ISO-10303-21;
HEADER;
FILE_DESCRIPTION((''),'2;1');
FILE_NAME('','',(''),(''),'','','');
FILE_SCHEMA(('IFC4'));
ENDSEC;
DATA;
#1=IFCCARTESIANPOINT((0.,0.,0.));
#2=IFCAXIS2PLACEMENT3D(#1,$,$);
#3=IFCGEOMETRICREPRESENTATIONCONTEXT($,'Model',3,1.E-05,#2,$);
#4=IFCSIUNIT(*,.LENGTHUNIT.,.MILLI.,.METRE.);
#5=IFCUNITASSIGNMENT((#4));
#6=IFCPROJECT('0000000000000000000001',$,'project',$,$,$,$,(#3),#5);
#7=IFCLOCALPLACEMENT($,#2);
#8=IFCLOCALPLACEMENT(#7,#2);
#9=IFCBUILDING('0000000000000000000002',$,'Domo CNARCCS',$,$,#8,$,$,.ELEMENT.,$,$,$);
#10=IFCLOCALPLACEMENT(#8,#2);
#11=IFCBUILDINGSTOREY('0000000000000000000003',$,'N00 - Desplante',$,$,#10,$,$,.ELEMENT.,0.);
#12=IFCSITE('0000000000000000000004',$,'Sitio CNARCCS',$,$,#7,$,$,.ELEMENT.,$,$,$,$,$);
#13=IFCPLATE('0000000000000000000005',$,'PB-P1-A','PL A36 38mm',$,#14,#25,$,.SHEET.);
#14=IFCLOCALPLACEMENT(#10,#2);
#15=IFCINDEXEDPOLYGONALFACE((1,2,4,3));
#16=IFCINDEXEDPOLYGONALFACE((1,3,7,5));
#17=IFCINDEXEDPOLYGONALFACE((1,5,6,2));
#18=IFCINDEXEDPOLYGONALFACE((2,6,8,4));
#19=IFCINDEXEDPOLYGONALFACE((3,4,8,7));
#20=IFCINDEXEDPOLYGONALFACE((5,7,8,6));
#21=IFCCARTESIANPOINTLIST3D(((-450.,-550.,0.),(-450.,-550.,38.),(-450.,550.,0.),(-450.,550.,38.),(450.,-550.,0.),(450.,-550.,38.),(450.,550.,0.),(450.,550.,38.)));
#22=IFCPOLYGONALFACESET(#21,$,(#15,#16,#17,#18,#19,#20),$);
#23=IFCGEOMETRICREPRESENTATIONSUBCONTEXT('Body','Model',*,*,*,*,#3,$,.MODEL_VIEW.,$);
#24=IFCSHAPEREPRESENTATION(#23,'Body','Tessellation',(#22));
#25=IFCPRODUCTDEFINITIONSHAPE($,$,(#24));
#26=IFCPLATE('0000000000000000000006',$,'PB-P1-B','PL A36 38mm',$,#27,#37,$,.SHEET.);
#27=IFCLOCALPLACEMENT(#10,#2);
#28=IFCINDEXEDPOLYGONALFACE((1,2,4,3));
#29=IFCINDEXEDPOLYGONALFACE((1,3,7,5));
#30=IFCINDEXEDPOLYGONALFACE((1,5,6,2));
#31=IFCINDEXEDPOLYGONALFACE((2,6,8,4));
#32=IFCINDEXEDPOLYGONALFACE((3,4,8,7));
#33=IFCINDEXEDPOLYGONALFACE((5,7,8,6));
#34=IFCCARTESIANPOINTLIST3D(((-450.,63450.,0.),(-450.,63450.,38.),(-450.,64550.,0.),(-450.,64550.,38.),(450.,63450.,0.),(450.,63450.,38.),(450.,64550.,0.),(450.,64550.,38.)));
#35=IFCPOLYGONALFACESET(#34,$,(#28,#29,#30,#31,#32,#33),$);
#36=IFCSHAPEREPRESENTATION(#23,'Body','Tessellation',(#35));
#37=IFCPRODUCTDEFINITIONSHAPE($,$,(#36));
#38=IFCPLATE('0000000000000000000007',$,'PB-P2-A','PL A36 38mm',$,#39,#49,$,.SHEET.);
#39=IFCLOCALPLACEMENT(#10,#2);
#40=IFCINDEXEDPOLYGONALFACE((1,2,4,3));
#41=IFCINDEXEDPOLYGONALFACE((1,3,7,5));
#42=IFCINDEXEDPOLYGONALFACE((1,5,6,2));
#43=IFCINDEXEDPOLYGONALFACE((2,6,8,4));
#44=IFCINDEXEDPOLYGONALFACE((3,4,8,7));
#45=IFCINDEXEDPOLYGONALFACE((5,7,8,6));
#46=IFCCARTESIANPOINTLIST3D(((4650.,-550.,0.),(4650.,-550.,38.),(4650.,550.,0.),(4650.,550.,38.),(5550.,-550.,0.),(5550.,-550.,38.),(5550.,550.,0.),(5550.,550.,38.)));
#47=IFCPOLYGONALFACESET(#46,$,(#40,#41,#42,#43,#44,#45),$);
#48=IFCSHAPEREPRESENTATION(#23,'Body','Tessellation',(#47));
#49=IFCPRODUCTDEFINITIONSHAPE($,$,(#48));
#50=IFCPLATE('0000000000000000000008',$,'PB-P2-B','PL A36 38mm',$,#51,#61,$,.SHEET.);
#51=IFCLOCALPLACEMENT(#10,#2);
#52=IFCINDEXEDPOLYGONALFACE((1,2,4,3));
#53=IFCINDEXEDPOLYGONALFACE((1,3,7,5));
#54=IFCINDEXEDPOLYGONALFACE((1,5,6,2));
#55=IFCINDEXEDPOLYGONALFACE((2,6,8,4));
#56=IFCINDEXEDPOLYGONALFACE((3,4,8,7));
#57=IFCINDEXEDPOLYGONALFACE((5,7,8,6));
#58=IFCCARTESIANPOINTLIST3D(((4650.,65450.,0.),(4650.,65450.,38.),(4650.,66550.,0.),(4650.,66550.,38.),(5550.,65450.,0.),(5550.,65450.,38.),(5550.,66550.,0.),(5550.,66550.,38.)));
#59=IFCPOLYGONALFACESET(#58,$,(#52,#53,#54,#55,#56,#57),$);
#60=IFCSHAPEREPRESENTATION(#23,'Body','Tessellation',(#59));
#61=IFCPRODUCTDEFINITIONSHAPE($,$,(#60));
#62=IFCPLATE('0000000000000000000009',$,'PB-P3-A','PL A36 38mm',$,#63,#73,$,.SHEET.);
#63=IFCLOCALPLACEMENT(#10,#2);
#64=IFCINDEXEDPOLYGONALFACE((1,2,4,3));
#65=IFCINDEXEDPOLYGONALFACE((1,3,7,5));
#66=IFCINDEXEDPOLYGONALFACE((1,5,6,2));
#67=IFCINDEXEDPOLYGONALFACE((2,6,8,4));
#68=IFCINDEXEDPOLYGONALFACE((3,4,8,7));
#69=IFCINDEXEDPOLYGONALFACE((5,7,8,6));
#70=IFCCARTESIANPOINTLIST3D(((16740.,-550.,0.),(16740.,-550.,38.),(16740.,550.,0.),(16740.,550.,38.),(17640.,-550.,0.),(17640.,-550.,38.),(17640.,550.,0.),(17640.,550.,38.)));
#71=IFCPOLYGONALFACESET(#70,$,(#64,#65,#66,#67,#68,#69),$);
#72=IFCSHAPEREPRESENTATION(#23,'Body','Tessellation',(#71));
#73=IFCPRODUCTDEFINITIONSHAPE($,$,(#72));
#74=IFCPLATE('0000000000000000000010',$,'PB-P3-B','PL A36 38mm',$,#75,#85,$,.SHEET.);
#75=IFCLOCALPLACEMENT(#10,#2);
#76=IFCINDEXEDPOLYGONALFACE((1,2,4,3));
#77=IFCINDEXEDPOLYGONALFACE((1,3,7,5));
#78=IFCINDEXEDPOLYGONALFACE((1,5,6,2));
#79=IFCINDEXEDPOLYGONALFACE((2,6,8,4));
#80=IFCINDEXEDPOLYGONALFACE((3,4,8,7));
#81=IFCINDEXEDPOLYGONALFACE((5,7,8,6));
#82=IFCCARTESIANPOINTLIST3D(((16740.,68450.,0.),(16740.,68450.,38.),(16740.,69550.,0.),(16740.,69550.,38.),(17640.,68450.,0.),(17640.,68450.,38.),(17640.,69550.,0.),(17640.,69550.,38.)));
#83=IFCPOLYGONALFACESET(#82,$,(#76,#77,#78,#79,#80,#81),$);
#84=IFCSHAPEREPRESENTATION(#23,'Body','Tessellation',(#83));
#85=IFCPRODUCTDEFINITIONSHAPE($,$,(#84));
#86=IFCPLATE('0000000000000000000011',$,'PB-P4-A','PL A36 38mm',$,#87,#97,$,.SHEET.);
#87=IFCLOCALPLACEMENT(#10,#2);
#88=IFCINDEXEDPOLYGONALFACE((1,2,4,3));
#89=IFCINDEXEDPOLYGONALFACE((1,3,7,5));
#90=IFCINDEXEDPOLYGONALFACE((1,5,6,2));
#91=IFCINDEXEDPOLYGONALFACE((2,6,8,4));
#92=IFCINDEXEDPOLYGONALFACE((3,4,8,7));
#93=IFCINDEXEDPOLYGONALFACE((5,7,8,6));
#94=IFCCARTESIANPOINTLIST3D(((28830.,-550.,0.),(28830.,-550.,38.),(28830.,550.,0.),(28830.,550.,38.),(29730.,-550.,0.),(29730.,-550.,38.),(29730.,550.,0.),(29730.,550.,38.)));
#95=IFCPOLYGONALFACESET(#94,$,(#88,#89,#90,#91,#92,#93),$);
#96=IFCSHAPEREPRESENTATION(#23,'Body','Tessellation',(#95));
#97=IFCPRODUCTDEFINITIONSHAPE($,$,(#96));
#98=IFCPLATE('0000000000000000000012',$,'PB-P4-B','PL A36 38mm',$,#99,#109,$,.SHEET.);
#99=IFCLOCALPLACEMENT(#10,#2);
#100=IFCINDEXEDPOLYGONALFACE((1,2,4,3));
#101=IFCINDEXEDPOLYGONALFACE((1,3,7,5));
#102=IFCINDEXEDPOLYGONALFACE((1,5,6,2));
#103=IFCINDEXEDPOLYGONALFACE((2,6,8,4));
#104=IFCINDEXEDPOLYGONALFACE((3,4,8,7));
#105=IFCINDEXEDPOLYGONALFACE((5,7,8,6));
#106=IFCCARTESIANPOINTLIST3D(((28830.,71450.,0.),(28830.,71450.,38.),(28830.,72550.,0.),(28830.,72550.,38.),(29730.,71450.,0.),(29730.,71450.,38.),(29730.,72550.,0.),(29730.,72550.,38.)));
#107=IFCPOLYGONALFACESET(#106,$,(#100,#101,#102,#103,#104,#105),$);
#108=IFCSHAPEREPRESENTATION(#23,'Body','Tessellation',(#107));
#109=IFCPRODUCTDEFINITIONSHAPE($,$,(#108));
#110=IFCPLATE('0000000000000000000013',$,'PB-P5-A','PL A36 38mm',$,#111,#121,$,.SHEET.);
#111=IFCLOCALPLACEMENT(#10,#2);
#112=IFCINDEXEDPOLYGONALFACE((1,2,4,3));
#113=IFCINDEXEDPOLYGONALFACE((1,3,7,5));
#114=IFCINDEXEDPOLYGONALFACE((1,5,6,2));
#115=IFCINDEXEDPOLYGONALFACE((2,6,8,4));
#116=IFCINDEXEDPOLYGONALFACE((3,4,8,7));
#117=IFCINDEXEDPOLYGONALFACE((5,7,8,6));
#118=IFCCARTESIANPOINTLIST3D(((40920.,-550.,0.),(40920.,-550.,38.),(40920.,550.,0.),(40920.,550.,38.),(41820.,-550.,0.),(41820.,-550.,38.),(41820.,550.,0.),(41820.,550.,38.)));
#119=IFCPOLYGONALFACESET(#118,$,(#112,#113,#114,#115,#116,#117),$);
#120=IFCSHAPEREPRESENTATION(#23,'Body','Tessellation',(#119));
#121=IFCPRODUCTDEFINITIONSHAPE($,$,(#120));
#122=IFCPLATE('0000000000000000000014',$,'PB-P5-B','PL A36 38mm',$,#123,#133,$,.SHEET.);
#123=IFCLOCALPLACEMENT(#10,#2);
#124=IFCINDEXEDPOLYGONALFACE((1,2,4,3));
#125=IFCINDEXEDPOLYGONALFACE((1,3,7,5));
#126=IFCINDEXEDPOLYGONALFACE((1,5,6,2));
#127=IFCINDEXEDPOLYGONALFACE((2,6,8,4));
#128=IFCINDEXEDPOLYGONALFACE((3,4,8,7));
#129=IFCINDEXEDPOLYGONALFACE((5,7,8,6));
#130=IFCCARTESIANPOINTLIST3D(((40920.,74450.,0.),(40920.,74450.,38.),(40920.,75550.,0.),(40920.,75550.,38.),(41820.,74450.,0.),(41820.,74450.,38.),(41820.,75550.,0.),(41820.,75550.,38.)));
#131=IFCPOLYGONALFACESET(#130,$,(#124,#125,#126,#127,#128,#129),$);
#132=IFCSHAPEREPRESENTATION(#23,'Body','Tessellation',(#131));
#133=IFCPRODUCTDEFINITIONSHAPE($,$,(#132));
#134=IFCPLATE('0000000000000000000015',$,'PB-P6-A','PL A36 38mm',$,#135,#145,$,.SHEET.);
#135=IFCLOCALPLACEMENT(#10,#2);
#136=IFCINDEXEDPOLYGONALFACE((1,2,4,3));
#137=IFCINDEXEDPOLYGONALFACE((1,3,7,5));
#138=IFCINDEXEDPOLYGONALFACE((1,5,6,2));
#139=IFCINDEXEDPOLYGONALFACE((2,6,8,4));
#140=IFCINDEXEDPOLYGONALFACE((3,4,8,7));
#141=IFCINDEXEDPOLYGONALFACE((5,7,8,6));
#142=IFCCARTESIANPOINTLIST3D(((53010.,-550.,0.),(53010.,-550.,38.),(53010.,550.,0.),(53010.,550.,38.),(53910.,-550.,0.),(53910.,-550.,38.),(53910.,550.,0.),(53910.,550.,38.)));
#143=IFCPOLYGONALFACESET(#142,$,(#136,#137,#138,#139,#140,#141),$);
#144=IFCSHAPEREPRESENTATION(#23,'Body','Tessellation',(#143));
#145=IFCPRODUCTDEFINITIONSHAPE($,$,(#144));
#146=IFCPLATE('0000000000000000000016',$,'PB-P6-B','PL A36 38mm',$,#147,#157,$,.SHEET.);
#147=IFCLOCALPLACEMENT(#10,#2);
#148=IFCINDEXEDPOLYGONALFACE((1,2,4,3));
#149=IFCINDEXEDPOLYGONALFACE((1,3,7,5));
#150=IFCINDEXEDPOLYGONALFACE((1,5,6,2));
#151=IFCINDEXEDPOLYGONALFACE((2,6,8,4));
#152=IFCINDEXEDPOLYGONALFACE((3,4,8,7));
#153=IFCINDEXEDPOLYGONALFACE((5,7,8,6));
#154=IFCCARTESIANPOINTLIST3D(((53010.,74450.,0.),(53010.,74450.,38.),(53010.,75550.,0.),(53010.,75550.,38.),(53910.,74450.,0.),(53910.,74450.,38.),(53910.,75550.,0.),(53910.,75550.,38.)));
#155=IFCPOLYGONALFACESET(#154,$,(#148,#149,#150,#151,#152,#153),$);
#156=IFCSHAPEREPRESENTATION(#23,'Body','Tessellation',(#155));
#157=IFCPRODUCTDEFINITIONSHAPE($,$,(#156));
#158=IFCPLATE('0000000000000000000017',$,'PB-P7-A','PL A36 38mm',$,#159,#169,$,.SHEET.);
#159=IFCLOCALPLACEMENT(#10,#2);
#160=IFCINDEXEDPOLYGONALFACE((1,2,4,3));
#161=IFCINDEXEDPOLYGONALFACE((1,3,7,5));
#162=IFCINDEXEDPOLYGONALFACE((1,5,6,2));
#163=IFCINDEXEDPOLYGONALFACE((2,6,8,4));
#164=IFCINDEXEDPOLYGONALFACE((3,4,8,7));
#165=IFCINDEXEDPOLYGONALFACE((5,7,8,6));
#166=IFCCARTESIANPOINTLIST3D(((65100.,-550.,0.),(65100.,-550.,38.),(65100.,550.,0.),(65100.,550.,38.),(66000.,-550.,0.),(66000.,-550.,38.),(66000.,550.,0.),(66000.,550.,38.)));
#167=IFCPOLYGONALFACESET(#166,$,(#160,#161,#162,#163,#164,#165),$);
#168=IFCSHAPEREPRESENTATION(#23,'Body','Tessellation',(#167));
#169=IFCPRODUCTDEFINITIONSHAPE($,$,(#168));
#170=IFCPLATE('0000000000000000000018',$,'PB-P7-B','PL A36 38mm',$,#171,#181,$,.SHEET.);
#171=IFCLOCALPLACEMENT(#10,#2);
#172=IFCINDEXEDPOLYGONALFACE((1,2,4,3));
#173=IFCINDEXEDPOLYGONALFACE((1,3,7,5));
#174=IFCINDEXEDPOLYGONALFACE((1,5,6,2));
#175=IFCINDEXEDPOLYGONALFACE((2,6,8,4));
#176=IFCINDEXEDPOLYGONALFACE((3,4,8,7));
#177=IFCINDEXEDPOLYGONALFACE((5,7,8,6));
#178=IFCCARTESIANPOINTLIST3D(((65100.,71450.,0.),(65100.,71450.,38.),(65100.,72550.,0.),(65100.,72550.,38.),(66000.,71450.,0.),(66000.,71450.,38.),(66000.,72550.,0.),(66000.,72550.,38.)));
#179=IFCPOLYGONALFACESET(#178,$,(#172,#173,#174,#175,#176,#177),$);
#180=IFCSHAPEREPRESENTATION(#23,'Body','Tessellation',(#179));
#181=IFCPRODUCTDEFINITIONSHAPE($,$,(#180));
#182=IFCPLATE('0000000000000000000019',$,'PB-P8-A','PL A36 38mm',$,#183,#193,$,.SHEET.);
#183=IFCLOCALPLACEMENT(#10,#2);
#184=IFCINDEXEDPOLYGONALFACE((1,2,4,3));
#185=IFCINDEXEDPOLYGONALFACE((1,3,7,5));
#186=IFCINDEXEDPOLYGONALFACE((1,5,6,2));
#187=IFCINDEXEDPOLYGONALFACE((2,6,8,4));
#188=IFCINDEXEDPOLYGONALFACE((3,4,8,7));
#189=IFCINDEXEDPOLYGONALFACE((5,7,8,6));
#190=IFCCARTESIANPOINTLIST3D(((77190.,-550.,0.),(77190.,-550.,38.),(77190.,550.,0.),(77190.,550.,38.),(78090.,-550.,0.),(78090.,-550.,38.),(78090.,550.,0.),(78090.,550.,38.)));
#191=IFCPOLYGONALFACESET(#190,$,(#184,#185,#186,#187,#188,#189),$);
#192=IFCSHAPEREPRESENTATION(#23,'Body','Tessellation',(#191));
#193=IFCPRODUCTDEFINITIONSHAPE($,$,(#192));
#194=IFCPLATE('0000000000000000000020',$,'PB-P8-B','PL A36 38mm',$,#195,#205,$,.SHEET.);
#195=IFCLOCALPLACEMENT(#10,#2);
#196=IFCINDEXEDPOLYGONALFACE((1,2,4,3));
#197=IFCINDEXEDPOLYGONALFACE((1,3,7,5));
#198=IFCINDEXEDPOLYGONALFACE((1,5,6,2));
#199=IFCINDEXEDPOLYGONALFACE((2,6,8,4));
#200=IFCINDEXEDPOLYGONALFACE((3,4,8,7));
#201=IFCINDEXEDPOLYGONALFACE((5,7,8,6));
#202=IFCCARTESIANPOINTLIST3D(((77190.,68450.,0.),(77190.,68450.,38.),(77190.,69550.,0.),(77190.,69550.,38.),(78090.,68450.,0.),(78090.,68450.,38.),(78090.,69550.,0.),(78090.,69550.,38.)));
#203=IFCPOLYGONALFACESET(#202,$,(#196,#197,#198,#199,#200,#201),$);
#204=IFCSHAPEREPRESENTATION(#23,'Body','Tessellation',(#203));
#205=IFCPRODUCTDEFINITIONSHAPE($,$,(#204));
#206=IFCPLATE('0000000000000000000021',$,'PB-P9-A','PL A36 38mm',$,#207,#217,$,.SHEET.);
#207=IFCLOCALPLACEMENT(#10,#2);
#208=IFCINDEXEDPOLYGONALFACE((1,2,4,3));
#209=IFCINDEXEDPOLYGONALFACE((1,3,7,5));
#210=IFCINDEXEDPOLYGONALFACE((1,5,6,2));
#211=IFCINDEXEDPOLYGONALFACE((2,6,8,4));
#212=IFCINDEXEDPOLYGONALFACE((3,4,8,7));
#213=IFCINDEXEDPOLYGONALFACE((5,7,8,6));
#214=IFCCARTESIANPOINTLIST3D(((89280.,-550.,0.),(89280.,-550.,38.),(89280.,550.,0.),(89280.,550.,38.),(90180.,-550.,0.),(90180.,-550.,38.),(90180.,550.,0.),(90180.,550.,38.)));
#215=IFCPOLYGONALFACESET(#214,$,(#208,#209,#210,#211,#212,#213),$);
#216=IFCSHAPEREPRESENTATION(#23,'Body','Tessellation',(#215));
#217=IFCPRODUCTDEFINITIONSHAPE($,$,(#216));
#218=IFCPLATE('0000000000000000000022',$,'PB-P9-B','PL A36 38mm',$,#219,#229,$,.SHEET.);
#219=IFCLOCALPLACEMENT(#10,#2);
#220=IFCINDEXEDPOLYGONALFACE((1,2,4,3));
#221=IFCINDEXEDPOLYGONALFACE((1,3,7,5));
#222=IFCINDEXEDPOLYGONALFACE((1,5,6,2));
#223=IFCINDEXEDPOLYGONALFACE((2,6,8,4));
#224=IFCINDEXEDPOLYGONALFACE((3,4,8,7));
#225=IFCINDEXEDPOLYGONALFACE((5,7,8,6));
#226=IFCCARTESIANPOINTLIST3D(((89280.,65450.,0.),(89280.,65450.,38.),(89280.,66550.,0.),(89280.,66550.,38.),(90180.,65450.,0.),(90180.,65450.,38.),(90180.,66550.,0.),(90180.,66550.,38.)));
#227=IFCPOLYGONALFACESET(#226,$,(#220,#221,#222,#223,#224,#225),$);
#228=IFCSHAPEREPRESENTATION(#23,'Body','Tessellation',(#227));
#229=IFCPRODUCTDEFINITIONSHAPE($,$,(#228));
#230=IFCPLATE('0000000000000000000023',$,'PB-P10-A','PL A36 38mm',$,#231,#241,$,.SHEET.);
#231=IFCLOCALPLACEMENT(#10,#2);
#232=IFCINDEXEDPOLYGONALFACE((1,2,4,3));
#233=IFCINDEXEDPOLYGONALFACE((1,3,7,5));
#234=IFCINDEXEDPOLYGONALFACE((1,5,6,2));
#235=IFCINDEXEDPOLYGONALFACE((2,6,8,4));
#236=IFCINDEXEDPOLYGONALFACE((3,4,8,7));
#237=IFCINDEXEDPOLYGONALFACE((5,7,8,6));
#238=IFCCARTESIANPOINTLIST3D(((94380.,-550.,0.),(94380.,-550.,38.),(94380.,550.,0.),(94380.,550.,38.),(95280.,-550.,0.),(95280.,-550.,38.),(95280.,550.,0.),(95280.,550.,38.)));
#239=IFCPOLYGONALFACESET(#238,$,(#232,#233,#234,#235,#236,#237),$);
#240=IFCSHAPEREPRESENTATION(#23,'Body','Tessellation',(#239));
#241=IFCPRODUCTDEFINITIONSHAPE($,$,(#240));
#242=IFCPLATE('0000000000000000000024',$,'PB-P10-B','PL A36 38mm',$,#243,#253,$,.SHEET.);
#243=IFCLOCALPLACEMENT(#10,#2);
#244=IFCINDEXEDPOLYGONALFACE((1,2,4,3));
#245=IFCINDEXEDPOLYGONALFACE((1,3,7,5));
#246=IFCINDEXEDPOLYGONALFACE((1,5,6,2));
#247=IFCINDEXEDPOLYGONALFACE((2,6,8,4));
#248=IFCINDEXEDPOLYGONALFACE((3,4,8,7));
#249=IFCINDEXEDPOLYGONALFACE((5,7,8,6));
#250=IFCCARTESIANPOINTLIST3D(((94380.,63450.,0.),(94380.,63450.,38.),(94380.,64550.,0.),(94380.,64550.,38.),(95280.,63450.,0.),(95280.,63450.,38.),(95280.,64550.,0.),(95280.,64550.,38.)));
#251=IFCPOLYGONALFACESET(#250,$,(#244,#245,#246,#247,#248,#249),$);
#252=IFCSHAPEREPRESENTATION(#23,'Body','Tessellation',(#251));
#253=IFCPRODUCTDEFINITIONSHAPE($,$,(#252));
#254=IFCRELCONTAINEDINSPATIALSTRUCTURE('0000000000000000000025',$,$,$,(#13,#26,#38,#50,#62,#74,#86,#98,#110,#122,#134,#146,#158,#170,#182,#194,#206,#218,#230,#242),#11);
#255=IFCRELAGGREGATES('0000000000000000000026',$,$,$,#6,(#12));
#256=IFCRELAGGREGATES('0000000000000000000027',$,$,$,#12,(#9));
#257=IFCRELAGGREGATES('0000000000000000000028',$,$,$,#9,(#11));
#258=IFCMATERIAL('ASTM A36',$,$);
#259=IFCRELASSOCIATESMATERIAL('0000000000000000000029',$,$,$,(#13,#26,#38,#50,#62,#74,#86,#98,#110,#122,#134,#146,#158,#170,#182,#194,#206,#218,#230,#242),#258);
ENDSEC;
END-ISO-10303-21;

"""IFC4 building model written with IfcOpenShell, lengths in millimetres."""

from ifc_helpers import new_model, si_unit, frame, origin, place, context, subcontext, project, spatial, polyline, outline, extrude, material, element, save


model = new_model("IFC4")

# Units and contexts
model_context = context("Model", 3, precision=1e-05, world=origin())
body_context = subcontext(model_context, "Body", "Model", "MODEL_VIEW")
ifc_project = project(units=[si_unit("LENGTHUNIT", "METRE", prefix="MILLI")], contexts=[model_context])

# Site, building, storey
site_placement = place(None, origin())
site = spatial("IfcSite", under=ifc_project, at=site_placement, Name="Sitio CNARCCS", CompositionType="ELEMENT")
building_placement = place(site_placement, origin())
building = spatial("IfcBuilding", under=site, at=building_placement, Name="Domo CNARCCS", CompositionType="ELEMENT")
storey_placement = place(building_placement, origin())
storey = spatial("IfcBuildingStorey", under=building, at=storey_placement, Name="N00 - Desplante", CompositionType="ELEMENT", Elevation=0.0)

# Plates
ifc_material = material(Name="ASTM A36")
for number, where, name in (
    (1, (0.0, 0.0, 0.0), "PB-P1-A"),
    (2, (0.0, 64000.0, 0.0), "PB-P1-B"),
    (3, (5100.0, 0.0, 0.0), "PB-P2-A"),
    (4, (5100.0, 66000.0, 0.0), "PB-P2-B"),
    (5, (17190.0, 0.0, 0.0), "PB-P3-A"),
    (6, (17190.0, 69000.0, 0.0), "PB-P3-B"),
    (7, (29280.0, 0.0, 0.0), "PB-P4-A"),
    (8, (29280.0, 72000.0, 0.0), "PB-P4-B"),
    (9, (41370.0, 0.0, 0.0), "PB-P5-A"),
    (10, (41370.0, 75000.0, 0.0), "PB-P5-B"),
    (11, (53460.0, 0.0, 0.0), "PB-P6-A"),
    (12, (53460.0, 75000.0, 0.0), "PB-P6-B"),
    (13, (65550.0, 0.0, 0.0), "PB-P7-A"),
    (14, (65550.0, 72000.0, 0.0), "PB-P7-B"),
    (15, (77640.0, 0.0, 0.0), "PB-P8-A"),
    (16, (77640.0, 69000.0, 0.0), "PB-P8-B"),
    (17, (89730.0, 0.0, 0.0), "PB-P9-A"),
    (18, (89730.0, 66000.0, 0.0), "PB-P9-B"),
    (19, (94830.0, 0.0, 0.0), "PB-P10-A"),
    (20, (94830.0, 64000.0, 0.0), "PB-P10-B"),
):
    element("IfcPlate", number, at=place(storey_placement, frame(where)), inside=storey, material=ifc_material, Name=name, Description="PL A36 38mm", PredefinedType="SHEET", context=body_context, shape_type="SweptSolid", body=[
        extrude(outline(polyline([(-450.0, -550.0), (450.0, -550.0), (450.0, 550.0), (-450.0, 550.0), (-450.0, -550.0)])), origin(), (0.0, 0.0, 1.0), 38.0),
    ])

save(model, "model.ifc")
